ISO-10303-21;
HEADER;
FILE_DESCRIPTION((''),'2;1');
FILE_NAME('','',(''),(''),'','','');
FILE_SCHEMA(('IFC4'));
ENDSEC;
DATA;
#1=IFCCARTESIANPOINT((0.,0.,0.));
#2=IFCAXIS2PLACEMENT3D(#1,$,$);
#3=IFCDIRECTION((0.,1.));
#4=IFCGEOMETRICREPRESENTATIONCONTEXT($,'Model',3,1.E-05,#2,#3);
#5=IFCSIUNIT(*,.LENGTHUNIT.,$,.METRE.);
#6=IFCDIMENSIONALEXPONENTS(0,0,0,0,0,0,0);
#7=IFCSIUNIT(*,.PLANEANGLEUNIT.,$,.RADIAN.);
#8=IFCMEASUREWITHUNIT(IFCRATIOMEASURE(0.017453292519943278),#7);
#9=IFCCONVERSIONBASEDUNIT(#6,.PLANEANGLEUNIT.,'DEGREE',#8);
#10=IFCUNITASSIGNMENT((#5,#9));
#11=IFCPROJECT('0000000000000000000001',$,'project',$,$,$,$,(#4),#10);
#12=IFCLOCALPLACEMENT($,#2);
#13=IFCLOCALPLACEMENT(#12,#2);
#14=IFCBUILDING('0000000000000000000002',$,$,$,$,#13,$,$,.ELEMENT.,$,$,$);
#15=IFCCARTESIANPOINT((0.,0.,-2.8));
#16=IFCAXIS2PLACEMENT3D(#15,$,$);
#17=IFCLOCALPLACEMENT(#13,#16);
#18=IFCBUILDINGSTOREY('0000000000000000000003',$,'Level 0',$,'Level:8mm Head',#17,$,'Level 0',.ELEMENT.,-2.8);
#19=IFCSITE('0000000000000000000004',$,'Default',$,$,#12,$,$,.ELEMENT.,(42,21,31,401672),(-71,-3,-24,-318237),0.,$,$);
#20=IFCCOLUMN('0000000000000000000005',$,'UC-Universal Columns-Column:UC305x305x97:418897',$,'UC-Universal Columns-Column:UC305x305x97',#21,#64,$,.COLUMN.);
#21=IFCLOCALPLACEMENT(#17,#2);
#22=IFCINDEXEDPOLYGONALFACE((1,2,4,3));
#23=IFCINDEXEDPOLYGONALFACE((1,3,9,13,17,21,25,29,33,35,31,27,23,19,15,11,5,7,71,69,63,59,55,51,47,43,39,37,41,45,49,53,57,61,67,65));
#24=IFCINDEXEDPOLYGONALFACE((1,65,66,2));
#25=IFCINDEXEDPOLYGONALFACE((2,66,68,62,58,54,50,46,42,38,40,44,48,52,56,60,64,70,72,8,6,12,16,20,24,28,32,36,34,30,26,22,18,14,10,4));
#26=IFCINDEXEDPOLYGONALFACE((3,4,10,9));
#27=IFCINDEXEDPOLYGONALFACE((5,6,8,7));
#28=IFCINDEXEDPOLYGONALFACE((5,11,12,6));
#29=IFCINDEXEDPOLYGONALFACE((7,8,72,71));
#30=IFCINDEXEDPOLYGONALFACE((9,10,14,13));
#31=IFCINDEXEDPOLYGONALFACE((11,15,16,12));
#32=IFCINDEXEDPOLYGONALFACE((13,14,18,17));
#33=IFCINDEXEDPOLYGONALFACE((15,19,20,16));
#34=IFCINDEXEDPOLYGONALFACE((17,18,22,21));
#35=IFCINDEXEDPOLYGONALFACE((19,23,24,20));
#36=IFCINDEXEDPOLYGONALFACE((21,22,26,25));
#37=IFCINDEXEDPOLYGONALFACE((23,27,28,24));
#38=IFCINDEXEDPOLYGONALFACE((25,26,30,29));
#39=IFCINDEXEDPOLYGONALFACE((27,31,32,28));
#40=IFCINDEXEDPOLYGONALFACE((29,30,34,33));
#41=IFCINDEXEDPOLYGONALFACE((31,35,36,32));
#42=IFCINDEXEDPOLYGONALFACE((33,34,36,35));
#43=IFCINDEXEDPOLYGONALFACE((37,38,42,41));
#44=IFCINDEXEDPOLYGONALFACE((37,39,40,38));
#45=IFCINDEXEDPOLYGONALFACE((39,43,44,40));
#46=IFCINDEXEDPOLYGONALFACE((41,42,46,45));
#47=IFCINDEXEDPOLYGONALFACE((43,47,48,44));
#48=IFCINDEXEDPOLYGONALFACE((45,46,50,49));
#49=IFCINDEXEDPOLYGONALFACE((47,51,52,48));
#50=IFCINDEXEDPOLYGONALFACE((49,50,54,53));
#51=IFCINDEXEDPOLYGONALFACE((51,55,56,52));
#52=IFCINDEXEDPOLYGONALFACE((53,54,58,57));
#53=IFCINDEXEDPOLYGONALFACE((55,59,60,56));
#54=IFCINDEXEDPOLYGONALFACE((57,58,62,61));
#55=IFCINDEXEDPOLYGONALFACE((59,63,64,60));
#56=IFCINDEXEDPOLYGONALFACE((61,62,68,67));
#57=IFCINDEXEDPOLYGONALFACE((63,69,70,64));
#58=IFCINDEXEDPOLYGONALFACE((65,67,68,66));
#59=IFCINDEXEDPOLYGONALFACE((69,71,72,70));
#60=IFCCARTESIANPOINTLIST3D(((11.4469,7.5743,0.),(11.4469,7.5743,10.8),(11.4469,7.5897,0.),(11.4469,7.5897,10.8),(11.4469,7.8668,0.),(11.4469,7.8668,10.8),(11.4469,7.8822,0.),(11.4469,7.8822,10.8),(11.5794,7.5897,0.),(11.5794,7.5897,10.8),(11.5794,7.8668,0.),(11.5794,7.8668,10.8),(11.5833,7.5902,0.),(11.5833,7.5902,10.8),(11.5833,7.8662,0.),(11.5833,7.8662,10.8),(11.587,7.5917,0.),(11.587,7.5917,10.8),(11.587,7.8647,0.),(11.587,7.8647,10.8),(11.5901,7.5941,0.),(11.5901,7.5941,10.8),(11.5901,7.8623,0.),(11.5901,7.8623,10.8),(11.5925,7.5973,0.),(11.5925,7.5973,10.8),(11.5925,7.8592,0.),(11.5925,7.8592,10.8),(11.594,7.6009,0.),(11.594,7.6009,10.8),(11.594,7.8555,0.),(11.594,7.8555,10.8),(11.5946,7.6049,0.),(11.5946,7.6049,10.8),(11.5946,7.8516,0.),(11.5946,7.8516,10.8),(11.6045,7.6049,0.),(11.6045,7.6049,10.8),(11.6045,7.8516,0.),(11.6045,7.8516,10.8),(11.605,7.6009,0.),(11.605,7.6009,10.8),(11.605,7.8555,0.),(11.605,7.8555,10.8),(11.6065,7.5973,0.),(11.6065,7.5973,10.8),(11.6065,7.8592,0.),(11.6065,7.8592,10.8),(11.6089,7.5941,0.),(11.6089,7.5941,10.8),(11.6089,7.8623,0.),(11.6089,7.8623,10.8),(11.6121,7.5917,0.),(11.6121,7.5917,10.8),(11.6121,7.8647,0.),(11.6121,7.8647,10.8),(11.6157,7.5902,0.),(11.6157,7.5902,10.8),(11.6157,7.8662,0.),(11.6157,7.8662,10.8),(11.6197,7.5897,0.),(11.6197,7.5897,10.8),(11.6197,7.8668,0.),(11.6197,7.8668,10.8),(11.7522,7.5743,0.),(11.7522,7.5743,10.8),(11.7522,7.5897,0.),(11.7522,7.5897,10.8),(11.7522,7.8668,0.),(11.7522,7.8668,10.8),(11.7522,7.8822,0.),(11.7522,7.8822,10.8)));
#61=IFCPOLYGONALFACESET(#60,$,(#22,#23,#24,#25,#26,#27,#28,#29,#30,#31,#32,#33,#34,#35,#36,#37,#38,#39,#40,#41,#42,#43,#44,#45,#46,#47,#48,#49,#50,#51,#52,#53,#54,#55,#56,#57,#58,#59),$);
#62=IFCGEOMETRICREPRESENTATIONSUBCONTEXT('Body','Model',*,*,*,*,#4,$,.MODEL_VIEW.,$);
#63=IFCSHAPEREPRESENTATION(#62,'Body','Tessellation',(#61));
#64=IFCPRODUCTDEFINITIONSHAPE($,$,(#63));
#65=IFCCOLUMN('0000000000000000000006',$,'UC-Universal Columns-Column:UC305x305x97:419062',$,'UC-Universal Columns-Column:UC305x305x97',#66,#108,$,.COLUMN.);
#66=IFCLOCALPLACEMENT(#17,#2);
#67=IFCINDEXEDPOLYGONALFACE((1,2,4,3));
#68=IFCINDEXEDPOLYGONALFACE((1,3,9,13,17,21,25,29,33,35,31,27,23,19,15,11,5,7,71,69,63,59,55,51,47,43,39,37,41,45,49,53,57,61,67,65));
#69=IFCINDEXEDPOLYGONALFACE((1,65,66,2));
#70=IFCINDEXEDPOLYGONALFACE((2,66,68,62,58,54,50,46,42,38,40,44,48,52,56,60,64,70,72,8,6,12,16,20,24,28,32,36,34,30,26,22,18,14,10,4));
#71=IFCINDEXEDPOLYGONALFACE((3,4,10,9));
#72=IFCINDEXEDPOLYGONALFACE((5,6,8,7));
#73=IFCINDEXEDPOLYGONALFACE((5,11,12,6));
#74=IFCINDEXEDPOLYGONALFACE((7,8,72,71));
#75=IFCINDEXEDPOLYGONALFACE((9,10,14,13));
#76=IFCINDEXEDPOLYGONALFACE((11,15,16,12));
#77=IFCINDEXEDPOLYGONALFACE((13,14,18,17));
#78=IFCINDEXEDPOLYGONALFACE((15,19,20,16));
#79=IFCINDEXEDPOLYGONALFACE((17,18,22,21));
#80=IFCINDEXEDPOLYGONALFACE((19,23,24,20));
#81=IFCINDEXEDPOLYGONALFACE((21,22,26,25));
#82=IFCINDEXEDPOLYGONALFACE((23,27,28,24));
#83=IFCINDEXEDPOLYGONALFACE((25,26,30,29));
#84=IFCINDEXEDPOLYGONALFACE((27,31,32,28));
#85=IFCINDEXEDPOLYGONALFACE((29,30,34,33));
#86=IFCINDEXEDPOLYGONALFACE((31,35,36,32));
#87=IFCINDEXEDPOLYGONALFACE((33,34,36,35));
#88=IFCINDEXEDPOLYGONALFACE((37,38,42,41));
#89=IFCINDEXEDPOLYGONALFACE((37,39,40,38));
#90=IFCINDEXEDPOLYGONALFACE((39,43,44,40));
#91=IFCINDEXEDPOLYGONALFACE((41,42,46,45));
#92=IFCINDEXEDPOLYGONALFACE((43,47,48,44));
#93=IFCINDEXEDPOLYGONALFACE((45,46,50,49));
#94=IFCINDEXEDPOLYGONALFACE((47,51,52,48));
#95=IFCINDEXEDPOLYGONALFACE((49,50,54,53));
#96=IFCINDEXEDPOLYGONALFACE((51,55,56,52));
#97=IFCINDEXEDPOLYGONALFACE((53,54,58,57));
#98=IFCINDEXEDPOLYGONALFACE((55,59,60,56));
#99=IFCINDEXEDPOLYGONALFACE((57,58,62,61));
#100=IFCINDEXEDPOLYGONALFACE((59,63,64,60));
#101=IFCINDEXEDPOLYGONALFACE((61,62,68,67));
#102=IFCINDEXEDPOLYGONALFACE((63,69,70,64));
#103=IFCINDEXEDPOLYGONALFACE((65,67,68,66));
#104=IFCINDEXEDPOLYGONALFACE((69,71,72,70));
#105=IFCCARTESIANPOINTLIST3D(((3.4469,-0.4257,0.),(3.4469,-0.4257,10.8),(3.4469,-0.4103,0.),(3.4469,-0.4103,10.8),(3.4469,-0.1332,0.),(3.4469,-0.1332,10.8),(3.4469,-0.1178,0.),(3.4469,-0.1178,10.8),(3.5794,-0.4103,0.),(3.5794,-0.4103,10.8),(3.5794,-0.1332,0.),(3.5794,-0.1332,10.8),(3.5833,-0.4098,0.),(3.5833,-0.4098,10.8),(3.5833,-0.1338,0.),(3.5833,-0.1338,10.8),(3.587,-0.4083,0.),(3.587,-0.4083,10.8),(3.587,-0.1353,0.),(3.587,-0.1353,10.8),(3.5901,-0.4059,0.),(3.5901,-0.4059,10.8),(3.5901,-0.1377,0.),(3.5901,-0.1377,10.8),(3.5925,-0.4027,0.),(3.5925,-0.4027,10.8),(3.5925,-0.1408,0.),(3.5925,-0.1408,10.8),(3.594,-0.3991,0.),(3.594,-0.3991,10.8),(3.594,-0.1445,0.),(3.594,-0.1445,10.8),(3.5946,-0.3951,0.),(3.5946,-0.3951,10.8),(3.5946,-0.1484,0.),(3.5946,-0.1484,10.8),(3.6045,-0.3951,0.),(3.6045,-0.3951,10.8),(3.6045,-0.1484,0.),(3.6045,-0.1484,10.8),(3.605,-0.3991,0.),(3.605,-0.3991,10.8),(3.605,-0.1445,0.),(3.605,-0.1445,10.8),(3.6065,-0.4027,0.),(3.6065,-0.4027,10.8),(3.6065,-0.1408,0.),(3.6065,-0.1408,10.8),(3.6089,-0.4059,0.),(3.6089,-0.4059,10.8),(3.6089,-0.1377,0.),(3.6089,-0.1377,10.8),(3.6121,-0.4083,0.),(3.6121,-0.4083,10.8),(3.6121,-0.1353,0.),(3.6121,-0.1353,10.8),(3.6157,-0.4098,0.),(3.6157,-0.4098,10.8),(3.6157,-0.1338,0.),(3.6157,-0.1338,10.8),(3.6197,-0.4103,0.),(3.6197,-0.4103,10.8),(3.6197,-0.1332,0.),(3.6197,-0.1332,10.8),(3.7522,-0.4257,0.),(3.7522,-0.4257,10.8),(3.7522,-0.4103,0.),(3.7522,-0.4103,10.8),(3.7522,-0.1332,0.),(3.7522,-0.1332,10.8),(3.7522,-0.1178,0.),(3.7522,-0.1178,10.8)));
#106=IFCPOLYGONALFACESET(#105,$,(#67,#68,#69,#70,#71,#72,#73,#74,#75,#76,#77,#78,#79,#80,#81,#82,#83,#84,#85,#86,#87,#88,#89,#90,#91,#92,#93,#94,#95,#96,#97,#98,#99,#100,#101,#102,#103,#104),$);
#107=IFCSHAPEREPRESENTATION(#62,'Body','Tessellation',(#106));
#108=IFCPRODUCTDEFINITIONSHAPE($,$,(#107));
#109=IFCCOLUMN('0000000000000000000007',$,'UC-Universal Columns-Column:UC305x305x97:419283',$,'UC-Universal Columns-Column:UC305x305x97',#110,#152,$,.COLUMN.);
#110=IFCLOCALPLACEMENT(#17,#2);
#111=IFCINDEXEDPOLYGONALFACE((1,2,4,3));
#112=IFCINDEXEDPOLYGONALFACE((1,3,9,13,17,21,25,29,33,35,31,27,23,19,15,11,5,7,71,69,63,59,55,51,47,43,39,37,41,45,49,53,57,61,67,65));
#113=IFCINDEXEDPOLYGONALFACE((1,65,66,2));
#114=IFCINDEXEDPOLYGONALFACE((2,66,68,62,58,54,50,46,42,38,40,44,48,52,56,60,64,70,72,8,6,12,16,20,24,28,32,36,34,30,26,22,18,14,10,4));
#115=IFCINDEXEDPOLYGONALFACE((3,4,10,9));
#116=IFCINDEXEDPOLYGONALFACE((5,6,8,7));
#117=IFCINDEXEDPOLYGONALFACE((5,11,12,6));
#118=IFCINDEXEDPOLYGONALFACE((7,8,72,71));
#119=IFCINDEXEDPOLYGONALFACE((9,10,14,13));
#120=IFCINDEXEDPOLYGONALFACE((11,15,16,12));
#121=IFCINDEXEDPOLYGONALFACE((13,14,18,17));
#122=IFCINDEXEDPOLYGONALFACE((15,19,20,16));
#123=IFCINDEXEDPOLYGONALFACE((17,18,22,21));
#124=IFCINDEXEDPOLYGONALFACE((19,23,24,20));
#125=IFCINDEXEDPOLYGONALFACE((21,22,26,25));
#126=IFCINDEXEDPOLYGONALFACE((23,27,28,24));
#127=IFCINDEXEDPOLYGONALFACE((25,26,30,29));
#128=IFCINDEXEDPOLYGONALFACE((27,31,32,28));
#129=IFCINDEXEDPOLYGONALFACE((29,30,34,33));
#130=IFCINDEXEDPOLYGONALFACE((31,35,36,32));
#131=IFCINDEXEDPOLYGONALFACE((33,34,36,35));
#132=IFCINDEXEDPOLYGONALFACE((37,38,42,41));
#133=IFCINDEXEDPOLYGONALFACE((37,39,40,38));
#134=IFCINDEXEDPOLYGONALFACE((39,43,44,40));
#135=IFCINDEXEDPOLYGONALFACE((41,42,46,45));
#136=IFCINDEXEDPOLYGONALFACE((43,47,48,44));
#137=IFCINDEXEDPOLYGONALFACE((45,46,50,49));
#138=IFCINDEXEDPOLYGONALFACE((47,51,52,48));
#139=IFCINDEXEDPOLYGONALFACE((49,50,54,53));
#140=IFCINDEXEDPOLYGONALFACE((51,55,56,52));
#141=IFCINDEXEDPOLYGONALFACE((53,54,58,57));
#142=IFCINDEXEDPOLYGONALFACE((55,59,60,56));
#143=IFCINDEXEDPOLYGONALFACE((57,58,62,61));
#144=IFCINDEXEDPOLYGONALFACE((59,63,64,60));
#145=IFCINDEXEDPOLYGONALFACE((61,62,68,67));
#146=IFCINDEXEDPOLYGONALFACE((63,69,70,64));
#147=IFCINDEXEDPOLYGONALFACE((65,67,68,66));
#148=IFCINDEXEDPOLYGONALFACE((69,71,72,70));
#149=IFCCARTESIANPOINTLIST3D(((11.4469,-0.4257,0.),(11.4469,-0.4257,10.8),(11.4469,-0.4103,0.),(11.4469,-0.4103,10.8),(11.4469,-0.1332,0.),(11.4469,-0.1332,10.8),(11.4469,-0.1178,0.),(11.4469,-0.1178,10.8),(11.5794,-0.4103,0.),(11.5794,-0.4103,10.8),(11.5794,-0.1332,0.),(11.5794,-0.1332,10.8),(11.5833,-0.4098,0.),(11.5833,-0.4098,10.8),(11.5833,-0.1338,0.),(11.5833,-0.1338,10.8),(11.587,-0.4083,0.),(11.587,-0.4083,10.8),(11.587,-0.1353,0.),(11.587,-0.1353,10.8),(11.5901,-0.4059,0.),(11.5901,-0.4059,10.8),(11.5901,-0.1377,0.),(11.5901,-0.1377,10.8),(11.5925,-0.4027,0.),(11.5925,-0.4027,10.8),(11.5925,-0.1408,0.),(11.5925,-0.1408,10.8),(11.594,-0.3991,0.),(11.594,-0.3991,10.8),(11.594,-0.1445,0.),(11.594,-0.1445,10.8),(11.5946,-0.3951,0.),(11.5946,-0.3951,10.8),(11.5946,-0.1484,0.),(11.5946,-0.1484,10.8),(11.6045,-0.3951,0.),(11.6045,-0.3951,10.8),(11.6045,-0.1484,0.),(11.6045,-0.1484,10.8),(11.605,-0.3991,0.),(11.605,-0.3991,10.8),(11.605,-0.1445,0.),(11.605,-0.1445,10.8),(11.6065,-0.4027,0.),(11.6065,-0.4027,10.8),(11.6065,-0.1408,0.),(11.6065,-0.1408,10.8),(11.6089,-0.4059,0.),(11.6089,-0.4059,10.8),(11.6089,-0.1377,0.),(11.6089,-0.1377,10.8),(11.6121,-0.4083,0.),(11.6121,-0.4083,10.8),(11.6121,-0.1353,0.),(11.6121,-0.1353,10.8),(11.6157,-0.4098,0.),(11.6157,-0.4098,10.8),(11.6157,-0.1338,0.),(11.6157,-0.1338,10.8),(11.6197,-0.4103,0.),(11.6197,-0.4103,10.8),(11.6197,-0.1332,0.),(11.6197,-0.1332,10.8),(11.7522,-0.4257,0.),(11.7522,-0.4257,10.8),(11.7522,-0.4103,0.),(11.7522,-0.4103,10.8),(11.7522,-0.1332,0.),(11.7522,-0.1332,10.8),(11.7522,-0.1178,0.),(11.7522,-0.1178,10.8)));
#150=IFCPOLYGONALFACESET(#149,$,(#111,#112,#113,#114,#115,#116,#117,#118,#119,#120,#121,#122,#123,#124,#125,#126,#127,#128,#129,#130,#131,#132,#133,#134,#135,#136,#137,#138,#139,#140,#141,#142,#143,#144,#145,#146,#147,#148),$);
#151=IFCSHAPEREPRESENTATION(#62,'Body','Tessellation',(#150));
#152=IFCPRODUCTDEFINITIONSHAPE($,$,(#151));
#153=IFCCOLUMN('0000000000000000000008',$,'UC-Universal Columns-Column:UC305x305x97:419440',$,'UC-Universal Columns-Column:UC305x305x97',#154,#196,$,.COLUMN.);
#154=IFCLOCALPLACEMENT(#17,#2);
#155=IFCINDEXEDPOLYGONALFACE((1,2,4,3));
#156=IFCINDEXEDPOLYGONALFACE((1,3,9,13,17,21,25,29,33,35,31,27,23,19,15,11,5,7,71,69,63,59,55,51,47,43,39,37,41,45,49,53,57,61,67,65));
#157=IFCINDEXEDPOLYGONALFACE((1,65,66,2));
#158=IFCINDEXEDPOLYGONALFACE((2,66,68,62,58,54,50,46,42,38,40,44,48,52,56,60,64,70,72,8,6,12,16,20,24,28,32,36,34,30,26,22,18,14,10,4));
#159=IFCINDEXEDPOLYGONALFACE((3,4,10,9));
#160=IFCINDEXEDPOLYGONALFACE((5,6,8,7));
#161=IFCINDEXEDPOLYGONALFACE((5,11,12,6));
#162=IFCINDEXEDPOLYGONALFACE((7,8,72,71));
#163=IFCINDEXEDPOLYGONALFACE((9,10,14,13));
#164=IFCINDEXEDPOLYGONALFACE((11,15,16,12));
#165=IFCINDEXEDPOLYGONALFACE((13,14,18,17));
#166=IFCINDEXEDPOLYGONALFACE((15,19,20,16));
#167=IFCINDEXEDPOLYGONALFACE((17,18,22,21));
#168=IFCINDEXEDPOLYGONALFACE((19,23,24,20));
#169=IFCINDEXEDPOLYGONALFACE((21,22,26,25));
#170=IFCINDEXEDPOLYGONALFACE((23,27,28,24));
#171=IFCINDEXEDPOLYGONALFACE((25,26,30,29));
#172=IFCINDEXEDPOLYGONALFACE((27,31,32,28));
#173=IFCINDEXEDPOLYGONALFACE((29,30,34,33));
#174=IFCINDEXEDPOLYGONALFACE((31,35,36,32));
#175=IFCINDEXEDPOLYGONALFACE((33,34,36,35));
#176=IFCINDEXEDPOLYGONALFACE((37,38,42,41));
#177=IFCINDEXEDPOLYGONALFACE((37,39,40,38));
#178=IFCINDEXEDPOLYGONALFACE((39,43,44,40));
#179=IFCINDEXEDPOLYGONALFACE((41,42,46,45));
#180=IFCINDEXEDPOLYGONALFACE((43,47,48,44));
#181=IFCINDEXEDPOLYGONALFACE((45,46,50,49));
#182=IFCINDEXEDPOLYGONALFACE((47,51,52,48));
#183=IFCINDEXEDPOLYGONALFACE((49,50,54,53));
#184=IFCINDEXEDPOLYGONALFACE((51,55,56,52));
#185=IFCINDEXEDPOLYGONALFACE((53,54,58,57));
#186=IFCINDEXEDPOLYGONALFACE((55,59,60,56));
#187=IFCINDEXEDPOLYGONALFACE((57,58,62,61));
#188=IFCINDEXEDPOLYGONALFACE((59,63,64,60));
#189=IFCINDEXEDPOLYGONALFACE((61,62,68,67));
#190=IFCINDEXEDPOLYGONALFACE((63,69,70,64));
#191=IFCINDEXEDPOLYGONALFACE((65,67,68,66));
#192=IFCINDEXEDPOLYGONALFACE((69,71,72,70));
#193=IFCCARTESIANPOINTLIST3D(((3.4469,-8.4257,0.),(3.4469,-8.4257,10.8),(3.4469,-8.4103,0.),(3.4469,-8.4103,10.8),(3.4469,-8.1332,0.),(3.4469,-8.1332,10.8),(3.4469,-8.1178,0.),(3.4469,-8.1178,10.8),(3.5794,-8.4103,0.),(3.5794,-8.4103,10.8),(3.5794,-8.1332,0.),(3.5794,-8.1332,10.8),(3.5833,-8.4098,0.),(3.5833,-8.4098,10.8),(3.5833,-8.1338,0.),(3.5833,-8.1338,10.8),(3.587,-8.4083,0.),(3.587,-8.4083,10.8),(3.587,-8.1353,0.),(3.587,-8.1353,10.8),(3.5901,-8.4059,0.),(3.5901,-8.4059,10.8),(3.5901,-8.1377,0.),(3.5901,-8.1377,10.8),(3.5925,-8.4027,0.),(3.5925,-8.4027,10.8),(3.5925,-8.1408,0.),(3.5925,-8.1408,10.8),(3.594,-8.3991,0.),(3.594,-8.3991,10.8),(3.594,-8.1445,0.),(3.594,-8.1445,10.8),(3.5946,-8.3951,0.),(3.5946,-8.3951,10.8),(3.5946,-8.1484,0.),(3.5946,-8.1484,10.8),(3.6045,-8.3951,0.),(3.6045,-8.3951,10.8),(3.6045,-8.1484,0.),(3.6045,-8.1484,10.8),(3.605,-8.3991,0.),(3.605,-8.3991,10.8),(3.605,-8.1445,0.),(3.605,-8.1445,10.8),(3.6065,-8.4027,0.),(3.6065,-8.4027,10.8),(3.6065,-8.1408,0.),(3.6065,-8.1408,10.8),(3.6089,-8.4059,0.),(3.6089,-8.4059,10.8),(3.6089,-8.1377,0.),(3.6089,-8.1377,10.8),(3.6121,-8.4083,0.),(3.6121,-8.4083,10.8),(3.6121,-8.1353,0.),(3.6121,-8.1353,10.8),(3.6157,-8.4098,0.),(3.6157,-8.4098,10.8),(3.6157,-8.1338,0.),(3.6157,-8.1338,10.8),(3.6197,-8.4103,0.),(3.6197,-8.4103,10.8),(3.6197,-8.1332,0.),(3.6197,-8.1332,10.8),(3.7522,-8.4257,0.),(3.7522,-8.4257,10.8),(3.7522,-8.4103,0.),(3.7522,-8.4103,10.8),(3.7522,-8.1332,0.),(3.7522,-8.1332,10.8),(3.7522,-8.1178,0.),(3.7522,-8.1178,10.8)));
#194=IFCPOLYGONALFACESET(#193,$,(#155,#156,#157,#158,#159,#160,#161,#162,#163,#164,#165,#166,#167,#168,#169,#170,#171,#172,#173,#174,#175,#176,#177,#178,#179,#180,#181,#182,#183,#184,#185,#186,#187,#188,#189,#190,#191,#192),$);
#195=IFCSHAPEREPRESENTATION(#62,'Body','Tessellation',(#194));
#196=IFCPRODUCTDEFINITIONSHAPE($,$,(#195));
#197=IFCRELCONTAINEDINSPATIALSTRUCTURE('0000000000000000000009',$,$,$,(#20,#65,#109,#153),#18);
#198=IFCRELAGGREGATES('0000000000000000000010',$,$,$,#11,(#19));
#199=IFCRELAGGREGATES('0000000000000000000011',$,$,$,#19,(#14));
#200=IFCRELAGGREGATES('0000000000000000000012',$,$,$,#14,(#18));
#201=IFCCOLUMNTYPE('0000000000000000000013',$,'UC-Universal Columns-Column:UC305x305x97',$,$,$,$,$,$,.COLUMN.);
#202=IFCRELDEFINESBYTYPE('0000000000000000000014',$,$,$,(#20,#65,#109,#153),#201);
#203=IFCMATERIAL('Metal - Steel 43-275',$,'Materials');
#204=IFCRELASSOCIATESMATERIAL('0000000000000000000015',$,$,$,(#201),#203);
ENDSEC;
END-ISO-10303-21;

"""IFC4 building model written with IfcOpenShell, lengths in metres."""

from ifc_helpers import new_model, entity, si_unit, converted_unit, direction, frame, frame_2d, origin, place, context, subcontext, project, spatial, i_section, extrude, source, transform, mapped, material, material_profile, profile_set, type_object, type_shapes, element, save


model = new_model("IFC4")

# Units and contexts
model_context = context("Model", 3, precision=1e-05, world=origin(), true_north=direction((0.0, 1.0)))
body_context = subcontext(model_context, "Body", "Model", "MODEL_VIEW")
ifc_project = project(units=[si_unit("LENGTHUNIT", "METRE"), converted_unit("PLANEANGLEUNIT", "DEGREE", entity("IfcRatioMeasure", 0.017453292519943278), si_unit("PLANEANGLEUNIT", "RADIAN"), dimensions=[0, 0, 0, 0, 0, 0, 0])], contexts=[model_context])

# Site, building, storey
site_placement = place(None, origin())
site = spatial("IfcSite", under=ifc_project, at=site_placement, Name="Default", CompositionType="ELEMENT", RefLatitude=(42, 21, 31, 401672), RefLongitude=(-71, -3, -24, -318237), RefElevation=0.0)
building_placement = place(site_placement, origin())
building = spatial("IfcBuilding", under=site, at=building_placement, CompositionType="ELEMENT")
storey_placement = place(building_placement, frame((0.0, 0.0, -2.8)))
storey = spatial("IfcBuildingStorey", under=building, at=storey_placement, Name="Level 0", ObjectType="Level:8mm Head", LongName="Level 0", CompositionType="ELEMENT", Elevation=-2.8)

# Columns
ifc_material_1 = material(Name="Metal - Steel 43-275", Category="Materials")
ifc_material_profile = material_profile(ifc_material_1, i_section(OverallWidth=0.3053, OverallDepth=0.3079, WebThickness=0.0099, FlangeThickness=0.0154, FilletRadius=0.0152, at=frame_2d((0.0, 0.0), x_axis=(0.0, 1.0))), Name="UC305x305x97")
ifc_profile_set = profile_set([ifc_material_profile], Name="UC305x305x97")
column_type = type_object("IfcColumnType", Name="UC-Universal Columns-Column:UC305x305x97", PredefinedType="COLUMN", material=ifc_profile_set)
shared_shape = source(origin(), body_context, "Body", "SweptSolid", [
    extrude(i_section(OverallWidth=0.3053, OverallDepth=0.3079, WebThickness=0.0099, FlangeThickness=0.0154, FilletRadius=0.0152, at=frame_2d((0.0, 0.0), x_axis=(0.0, 1.0))), frame((0.0, 0.0, -2.8), z_axis=(0.0, 0.0, 1.0), x_axis=(0.0, -1.0, 0.0)), (0.0, 0.0, 1.0), 10.8),
])
type_shapes(column_type, [shared_shape])
for number, where, name in (
    (1, (11.5995, 7.7282, 2.8), "UC-Universal Columns-Column:UC305x305x97:418897"),
    (2, (3.5995, -0.2718, 2.8), "UC-Universal Columns-Column:UC305x305x97:419062"),
    (3, (11.5995, -0.2718, 2.8), "UC-Universal Columns-Column:UC305x305x97:419283"),
    (4, (3.5995, -8.2718, 2.8), "UC-Universal Columns-Column:UC305x305x97:419440"),
):
    element("IfcColumn", number, at=place(storey_placement, frame(where)), inside=storey, type_object=column_type, Name=name, ObjectType="UC-Universal Columns-Column:UC305x305x97", PredefinedType="COLUMN", context=body_context, shape_type="MappedRepresentation", body=[
        mapped(shared_shape, transform((0.0, 0.0, 0.0), scale=1.0)),
    ])

save(model, "model.ifc")
